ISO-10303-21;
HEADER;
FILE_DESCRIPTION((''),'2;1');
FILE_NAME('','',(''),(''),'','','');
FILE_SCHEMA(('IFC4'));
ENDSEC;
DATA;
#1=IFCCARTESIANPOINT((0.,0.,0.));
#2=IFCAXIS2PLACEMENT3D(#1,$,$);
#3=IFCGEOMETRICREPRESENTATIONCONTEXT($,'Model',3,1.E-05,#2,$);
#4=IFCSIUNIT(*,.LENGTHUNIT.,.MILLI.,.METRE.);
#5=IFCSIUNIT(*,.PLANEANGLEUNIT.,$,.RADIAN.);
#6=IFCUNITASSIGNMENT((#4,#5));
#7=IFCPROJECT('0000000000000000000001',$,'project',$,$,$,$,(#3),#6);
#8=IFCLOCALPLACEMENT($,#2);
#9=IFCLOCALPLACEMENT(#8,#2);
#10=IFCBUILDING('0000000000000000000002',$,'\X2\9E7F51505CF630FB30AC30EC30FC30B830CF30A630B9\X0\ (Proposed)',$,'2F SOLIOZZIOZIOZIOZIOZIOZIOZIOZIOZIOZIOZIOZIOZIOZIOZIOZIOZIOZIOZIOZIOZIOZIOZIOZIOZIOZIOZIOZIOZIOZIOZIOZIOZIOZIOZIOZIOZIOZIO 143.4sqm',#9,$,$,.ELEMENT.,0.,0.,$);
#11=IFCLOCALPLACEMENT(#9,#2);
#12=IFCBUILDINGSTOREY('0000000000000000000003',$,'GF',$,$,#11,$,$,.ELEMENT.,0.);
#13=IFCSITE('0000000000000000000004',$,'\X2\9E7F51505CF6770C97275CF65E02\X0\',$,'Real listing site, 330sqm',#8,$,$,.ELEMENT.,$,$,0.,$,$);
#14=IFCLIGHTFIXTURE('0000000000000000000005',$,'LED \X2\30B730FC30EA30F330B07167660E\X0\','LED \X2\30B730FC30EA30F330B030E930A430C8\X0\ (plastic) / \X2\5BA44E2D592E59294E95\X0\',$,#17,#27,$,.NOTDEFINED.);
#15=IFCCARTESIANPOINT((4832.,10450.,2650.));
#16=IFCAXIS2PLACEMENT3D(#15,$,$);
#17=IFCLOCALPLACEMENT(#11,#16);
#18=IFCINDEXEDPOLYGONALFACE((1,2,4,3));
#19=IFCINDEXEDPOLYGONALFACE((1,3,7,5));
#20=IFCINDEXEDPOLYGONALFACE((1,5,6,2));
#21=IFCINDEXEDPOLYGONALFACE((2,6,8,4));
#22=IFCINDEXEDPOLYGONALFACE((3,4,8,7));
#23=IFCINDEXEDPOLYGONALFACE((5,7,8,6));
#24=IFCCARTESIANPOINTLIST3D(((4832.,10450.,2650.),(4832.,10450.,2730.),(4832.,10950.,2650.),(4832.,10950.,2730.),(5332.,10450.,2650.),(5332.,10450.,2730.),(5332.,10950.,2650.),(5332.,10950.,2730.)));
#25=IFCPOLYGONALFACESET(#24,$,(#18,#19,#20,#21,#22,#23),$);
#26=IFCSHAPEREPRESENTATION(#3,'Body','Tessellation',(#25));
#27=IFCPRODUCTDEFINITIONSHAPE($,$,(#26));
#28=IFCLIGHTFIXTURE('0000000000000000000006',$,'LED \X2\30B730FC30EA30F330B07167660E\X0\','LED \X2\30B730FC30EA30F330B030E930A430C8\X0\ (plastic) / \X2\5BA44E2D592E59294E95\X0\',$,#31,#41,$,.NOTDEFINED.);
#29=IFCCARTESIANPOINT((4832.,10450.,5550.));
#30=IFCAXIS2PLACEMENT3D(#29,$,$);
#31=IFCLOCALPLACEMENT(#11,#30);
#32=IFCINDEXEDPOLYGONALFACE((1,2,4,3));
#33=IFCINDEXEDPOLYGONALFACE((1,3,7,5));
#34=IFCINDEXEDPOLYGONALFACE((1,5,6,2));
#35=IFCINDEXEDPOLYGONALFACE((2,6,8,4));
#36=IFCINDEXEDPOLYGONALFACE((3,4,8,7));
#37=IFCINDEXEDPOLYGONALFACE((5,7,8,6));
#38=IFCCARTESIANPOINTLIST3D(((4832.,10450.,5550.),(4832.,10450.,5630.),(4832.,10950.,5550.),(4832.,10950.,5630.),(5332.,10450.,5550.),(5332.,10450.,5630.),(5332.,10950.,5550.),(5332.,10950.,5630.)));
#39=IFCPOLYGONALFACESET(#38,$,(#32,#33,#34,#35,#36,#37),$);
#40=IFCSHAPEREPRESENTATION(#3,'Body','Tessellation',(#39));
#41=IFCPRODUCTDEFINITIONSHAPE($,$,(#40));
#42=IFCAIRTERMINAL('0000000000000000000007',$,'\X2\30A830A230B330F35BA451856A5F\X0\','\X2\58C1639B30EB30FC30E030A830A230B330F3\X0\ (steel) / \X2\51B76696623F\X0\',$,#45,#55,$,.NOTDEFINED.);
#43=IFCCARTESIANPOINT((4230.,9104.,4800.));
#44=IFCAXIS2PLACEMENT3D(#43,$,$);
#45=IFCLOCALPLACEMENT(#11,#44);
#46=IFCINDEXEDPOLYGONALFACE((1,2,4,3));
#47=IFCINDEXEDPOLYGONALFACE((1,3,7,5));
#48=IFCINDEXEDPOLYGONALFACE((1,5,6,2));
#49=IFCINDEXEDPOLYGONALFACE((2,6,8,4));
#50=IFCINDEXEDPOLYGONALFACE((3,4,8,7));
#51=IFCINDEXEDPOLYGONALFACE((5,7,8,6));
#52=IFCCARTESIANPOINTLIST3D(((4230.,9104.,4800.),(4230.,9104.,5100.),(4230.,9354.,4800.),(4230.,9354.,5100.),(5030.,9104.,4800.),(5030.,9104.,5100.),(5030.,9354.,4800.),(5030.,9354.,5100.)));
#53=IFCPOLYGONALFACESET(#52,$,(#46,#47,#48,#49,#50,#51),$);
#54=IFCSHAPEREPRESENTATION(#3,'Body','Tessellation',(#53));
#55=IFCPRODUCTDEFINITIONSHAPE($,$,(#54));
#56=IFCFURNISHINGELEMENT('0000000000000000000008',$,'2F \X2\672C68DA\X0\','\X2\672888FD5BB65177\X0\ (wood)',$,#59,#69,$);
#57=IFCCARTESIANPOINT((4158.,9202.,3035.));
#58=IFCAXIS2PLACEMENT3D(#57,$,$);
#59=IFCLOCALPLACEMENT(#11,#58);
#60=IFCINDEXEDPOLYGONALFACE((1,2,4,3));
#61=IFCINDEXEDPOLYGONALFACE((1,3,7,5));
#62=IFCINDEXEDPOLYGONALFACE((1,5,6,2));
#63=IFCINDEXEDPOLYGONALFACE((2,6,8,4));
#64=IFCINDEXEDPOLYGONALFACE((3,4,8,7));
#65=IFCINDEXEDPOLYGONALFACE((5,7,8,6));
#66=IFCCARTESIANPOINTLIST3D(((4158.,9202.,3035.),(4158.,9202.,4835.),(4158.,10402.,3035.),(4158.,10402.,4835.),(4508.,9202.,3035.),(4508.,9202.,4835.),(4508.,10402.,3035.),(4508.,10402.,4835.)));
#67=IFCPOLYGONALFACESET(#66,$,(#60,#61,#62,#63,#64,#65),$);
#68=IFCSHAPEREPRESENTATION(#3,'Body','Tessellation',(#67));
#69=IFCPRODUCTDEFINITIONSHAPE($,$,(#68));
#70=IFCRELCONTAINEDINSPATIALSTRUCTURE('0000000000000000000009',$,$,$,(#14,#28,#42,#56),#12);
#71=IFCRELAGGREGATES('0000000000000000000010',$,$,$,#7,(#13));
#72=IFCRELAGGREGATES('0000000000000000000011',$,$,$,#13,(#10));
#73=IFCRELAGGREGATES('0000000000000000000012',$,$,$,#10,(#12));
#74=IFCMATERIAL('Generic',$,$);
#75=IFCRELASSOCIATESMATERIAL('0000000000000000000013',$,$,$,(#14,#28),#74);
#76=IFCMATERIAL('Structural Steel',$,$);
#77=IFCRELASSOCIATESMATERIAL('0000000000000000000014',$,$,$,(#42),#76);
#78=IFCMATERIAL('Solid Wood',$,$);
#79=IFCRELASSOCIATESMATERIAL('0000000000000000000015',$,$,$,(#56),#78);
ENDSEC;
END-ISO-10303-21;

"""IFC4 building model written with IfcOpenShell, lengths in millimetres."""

from ifc_helpers import new_model, si_unit, frame, frame_2d, origin, place, context, project, spatial, rectangle, extrude, material, element, save


model = new_model("IFC4")

# Units and contexts
model_context = context("Model", 3, precision=1e-05, world=origin())
ifc_project = project(units=[si_unit("LENGTHUNIT", "METRE", prefix="MILLI"), si_unit("PLANEANGLEUNIT", "RADIAN")], contexts=[model_context])

# Site, building, storey
site_placement = place(None, origin())
site = spatial("IfcSite", under=ifc_project, at=site_placement, Name="鹿児島県霧島市", ObjectType="Real listing site, 330sqm", CompositionType="ELEMENT", RefElevation=0.0)
building_placement = place(site_placement, origin())
building = spatial("IfcBuilding", under=site, at=building_placement, Name="鹿児島・ガレージハウス (Proposed)", ObjectType="2F SOLIOZZIOZIOZIOZIOZIOZIOZIOZIOZIOZIOZIOZIOZIOZIOZIOZIOZIOZIOZIOZIOZIOZIOZIOZIOZIOZIOZIOZIOZIOZIOZIOZIOZIOZIOZIOZIOZIOZIO 143.4sqm", CompositionType="ELEMENT", ElevationOfRefHeight=0.0, ElevationOfTerrain=0.0)
storey_placement = place(building_placement, origin())
storey = spatial("IfcBuildingStorey", under=building, at=storey_placement, Name="GF", CompositionType="ELEMENT", Elevation=0.0)

# Shared definitions
ifc_material_1 = material(Name="Solid Wood")

# Shared definitions
ifc_material_2 = material(Name="Structural Steel")

# Shared definitions
ifc_material_3 = material(Name="Generic")

# Light fixtures
light_fixture_1_placement = place(storey_placement, frame((4832.0, 10450.0, 2650.0)))
element("IfcLightFixture", 1, at=light_fixture_1_placement, inside=storey, material=ifc_material_3, Name="LED シーリング照明", Description="LED シーリングライト (plastic) / 室中央天井", PredefinedType="NOTDEFINED", context=model_context, shape_type="SweptSolid", body=[
    extrude(rectangle(XDim=500.0, YDim=500.0, at=frame_2d((250.0, 250.0))), frame((4832.0, 10450.0, 2650.0)), (0.0, 0.0, 1.0), 80.0),
])
light_fixture_2_placement = place(storey_placement, frame((4832.0, 10450.0, 5550.0)))
element("IfcLightFixture", 2, at=light_fixture_2_placement, inside=storey, material=ifc_material_3, Name="LED シーリング照明", Description="LED シーリングライト (plastic) / 室中央天井", PredefinedType="NOTDEFINED", context=model_context, shape_type="SweptSolid", body=[
    extrude(rectangle(XDim=500.0, YDim=500.0, at=frame_2d((250.0, 250.0))), frame((4832.0, 10450.0, 5550.0)), (0.0, 0.0, 1.0), 80.0),
])

# Air terminal
air_terminal_placement = place(storey_placement, frame((4230.0, 9104.0, 4800.0)))
element("IfcAirTerminal", 3, at=air_terminal_placement, inside=storey, material=ifc_material_2, Name="エアコン室内機", Description="壁掛ルームエアコン (steel) / 冷暖房", PredefinedType="NOTDEFINED", context=model_context, shape_type="SweptSolid", body=[
    extrude(rectangle(XDim=800.0, YDim=250.0, at=frame_2d((400.0, 125.0))), frame((4230.0, 9104.0, 4800.0)), (0.0, 0.0, 1.0), 300.0),
])

# Furnishing element
furnishing_placement = place(storey_placement, frame((4158.0, 9202.0, 3035.0)))
element("IfcFurnishingElement", 4, at=furnishing_placement, inside=storey, material=ifc_material_1, Name="2F 本棚", Description="木製家具 (wood)", context=model_context, shape_type="SweptSolid", body=[
    extrude(rectangle(XDim=350.0, YDim=1200.0, at=frame_2d((175.0, 600.0))), frame((4158.0, 9202.0, 3035.0)), (0.0, 0.0, 1.0), 1800.0),
])

save(model, "model.ifc")
